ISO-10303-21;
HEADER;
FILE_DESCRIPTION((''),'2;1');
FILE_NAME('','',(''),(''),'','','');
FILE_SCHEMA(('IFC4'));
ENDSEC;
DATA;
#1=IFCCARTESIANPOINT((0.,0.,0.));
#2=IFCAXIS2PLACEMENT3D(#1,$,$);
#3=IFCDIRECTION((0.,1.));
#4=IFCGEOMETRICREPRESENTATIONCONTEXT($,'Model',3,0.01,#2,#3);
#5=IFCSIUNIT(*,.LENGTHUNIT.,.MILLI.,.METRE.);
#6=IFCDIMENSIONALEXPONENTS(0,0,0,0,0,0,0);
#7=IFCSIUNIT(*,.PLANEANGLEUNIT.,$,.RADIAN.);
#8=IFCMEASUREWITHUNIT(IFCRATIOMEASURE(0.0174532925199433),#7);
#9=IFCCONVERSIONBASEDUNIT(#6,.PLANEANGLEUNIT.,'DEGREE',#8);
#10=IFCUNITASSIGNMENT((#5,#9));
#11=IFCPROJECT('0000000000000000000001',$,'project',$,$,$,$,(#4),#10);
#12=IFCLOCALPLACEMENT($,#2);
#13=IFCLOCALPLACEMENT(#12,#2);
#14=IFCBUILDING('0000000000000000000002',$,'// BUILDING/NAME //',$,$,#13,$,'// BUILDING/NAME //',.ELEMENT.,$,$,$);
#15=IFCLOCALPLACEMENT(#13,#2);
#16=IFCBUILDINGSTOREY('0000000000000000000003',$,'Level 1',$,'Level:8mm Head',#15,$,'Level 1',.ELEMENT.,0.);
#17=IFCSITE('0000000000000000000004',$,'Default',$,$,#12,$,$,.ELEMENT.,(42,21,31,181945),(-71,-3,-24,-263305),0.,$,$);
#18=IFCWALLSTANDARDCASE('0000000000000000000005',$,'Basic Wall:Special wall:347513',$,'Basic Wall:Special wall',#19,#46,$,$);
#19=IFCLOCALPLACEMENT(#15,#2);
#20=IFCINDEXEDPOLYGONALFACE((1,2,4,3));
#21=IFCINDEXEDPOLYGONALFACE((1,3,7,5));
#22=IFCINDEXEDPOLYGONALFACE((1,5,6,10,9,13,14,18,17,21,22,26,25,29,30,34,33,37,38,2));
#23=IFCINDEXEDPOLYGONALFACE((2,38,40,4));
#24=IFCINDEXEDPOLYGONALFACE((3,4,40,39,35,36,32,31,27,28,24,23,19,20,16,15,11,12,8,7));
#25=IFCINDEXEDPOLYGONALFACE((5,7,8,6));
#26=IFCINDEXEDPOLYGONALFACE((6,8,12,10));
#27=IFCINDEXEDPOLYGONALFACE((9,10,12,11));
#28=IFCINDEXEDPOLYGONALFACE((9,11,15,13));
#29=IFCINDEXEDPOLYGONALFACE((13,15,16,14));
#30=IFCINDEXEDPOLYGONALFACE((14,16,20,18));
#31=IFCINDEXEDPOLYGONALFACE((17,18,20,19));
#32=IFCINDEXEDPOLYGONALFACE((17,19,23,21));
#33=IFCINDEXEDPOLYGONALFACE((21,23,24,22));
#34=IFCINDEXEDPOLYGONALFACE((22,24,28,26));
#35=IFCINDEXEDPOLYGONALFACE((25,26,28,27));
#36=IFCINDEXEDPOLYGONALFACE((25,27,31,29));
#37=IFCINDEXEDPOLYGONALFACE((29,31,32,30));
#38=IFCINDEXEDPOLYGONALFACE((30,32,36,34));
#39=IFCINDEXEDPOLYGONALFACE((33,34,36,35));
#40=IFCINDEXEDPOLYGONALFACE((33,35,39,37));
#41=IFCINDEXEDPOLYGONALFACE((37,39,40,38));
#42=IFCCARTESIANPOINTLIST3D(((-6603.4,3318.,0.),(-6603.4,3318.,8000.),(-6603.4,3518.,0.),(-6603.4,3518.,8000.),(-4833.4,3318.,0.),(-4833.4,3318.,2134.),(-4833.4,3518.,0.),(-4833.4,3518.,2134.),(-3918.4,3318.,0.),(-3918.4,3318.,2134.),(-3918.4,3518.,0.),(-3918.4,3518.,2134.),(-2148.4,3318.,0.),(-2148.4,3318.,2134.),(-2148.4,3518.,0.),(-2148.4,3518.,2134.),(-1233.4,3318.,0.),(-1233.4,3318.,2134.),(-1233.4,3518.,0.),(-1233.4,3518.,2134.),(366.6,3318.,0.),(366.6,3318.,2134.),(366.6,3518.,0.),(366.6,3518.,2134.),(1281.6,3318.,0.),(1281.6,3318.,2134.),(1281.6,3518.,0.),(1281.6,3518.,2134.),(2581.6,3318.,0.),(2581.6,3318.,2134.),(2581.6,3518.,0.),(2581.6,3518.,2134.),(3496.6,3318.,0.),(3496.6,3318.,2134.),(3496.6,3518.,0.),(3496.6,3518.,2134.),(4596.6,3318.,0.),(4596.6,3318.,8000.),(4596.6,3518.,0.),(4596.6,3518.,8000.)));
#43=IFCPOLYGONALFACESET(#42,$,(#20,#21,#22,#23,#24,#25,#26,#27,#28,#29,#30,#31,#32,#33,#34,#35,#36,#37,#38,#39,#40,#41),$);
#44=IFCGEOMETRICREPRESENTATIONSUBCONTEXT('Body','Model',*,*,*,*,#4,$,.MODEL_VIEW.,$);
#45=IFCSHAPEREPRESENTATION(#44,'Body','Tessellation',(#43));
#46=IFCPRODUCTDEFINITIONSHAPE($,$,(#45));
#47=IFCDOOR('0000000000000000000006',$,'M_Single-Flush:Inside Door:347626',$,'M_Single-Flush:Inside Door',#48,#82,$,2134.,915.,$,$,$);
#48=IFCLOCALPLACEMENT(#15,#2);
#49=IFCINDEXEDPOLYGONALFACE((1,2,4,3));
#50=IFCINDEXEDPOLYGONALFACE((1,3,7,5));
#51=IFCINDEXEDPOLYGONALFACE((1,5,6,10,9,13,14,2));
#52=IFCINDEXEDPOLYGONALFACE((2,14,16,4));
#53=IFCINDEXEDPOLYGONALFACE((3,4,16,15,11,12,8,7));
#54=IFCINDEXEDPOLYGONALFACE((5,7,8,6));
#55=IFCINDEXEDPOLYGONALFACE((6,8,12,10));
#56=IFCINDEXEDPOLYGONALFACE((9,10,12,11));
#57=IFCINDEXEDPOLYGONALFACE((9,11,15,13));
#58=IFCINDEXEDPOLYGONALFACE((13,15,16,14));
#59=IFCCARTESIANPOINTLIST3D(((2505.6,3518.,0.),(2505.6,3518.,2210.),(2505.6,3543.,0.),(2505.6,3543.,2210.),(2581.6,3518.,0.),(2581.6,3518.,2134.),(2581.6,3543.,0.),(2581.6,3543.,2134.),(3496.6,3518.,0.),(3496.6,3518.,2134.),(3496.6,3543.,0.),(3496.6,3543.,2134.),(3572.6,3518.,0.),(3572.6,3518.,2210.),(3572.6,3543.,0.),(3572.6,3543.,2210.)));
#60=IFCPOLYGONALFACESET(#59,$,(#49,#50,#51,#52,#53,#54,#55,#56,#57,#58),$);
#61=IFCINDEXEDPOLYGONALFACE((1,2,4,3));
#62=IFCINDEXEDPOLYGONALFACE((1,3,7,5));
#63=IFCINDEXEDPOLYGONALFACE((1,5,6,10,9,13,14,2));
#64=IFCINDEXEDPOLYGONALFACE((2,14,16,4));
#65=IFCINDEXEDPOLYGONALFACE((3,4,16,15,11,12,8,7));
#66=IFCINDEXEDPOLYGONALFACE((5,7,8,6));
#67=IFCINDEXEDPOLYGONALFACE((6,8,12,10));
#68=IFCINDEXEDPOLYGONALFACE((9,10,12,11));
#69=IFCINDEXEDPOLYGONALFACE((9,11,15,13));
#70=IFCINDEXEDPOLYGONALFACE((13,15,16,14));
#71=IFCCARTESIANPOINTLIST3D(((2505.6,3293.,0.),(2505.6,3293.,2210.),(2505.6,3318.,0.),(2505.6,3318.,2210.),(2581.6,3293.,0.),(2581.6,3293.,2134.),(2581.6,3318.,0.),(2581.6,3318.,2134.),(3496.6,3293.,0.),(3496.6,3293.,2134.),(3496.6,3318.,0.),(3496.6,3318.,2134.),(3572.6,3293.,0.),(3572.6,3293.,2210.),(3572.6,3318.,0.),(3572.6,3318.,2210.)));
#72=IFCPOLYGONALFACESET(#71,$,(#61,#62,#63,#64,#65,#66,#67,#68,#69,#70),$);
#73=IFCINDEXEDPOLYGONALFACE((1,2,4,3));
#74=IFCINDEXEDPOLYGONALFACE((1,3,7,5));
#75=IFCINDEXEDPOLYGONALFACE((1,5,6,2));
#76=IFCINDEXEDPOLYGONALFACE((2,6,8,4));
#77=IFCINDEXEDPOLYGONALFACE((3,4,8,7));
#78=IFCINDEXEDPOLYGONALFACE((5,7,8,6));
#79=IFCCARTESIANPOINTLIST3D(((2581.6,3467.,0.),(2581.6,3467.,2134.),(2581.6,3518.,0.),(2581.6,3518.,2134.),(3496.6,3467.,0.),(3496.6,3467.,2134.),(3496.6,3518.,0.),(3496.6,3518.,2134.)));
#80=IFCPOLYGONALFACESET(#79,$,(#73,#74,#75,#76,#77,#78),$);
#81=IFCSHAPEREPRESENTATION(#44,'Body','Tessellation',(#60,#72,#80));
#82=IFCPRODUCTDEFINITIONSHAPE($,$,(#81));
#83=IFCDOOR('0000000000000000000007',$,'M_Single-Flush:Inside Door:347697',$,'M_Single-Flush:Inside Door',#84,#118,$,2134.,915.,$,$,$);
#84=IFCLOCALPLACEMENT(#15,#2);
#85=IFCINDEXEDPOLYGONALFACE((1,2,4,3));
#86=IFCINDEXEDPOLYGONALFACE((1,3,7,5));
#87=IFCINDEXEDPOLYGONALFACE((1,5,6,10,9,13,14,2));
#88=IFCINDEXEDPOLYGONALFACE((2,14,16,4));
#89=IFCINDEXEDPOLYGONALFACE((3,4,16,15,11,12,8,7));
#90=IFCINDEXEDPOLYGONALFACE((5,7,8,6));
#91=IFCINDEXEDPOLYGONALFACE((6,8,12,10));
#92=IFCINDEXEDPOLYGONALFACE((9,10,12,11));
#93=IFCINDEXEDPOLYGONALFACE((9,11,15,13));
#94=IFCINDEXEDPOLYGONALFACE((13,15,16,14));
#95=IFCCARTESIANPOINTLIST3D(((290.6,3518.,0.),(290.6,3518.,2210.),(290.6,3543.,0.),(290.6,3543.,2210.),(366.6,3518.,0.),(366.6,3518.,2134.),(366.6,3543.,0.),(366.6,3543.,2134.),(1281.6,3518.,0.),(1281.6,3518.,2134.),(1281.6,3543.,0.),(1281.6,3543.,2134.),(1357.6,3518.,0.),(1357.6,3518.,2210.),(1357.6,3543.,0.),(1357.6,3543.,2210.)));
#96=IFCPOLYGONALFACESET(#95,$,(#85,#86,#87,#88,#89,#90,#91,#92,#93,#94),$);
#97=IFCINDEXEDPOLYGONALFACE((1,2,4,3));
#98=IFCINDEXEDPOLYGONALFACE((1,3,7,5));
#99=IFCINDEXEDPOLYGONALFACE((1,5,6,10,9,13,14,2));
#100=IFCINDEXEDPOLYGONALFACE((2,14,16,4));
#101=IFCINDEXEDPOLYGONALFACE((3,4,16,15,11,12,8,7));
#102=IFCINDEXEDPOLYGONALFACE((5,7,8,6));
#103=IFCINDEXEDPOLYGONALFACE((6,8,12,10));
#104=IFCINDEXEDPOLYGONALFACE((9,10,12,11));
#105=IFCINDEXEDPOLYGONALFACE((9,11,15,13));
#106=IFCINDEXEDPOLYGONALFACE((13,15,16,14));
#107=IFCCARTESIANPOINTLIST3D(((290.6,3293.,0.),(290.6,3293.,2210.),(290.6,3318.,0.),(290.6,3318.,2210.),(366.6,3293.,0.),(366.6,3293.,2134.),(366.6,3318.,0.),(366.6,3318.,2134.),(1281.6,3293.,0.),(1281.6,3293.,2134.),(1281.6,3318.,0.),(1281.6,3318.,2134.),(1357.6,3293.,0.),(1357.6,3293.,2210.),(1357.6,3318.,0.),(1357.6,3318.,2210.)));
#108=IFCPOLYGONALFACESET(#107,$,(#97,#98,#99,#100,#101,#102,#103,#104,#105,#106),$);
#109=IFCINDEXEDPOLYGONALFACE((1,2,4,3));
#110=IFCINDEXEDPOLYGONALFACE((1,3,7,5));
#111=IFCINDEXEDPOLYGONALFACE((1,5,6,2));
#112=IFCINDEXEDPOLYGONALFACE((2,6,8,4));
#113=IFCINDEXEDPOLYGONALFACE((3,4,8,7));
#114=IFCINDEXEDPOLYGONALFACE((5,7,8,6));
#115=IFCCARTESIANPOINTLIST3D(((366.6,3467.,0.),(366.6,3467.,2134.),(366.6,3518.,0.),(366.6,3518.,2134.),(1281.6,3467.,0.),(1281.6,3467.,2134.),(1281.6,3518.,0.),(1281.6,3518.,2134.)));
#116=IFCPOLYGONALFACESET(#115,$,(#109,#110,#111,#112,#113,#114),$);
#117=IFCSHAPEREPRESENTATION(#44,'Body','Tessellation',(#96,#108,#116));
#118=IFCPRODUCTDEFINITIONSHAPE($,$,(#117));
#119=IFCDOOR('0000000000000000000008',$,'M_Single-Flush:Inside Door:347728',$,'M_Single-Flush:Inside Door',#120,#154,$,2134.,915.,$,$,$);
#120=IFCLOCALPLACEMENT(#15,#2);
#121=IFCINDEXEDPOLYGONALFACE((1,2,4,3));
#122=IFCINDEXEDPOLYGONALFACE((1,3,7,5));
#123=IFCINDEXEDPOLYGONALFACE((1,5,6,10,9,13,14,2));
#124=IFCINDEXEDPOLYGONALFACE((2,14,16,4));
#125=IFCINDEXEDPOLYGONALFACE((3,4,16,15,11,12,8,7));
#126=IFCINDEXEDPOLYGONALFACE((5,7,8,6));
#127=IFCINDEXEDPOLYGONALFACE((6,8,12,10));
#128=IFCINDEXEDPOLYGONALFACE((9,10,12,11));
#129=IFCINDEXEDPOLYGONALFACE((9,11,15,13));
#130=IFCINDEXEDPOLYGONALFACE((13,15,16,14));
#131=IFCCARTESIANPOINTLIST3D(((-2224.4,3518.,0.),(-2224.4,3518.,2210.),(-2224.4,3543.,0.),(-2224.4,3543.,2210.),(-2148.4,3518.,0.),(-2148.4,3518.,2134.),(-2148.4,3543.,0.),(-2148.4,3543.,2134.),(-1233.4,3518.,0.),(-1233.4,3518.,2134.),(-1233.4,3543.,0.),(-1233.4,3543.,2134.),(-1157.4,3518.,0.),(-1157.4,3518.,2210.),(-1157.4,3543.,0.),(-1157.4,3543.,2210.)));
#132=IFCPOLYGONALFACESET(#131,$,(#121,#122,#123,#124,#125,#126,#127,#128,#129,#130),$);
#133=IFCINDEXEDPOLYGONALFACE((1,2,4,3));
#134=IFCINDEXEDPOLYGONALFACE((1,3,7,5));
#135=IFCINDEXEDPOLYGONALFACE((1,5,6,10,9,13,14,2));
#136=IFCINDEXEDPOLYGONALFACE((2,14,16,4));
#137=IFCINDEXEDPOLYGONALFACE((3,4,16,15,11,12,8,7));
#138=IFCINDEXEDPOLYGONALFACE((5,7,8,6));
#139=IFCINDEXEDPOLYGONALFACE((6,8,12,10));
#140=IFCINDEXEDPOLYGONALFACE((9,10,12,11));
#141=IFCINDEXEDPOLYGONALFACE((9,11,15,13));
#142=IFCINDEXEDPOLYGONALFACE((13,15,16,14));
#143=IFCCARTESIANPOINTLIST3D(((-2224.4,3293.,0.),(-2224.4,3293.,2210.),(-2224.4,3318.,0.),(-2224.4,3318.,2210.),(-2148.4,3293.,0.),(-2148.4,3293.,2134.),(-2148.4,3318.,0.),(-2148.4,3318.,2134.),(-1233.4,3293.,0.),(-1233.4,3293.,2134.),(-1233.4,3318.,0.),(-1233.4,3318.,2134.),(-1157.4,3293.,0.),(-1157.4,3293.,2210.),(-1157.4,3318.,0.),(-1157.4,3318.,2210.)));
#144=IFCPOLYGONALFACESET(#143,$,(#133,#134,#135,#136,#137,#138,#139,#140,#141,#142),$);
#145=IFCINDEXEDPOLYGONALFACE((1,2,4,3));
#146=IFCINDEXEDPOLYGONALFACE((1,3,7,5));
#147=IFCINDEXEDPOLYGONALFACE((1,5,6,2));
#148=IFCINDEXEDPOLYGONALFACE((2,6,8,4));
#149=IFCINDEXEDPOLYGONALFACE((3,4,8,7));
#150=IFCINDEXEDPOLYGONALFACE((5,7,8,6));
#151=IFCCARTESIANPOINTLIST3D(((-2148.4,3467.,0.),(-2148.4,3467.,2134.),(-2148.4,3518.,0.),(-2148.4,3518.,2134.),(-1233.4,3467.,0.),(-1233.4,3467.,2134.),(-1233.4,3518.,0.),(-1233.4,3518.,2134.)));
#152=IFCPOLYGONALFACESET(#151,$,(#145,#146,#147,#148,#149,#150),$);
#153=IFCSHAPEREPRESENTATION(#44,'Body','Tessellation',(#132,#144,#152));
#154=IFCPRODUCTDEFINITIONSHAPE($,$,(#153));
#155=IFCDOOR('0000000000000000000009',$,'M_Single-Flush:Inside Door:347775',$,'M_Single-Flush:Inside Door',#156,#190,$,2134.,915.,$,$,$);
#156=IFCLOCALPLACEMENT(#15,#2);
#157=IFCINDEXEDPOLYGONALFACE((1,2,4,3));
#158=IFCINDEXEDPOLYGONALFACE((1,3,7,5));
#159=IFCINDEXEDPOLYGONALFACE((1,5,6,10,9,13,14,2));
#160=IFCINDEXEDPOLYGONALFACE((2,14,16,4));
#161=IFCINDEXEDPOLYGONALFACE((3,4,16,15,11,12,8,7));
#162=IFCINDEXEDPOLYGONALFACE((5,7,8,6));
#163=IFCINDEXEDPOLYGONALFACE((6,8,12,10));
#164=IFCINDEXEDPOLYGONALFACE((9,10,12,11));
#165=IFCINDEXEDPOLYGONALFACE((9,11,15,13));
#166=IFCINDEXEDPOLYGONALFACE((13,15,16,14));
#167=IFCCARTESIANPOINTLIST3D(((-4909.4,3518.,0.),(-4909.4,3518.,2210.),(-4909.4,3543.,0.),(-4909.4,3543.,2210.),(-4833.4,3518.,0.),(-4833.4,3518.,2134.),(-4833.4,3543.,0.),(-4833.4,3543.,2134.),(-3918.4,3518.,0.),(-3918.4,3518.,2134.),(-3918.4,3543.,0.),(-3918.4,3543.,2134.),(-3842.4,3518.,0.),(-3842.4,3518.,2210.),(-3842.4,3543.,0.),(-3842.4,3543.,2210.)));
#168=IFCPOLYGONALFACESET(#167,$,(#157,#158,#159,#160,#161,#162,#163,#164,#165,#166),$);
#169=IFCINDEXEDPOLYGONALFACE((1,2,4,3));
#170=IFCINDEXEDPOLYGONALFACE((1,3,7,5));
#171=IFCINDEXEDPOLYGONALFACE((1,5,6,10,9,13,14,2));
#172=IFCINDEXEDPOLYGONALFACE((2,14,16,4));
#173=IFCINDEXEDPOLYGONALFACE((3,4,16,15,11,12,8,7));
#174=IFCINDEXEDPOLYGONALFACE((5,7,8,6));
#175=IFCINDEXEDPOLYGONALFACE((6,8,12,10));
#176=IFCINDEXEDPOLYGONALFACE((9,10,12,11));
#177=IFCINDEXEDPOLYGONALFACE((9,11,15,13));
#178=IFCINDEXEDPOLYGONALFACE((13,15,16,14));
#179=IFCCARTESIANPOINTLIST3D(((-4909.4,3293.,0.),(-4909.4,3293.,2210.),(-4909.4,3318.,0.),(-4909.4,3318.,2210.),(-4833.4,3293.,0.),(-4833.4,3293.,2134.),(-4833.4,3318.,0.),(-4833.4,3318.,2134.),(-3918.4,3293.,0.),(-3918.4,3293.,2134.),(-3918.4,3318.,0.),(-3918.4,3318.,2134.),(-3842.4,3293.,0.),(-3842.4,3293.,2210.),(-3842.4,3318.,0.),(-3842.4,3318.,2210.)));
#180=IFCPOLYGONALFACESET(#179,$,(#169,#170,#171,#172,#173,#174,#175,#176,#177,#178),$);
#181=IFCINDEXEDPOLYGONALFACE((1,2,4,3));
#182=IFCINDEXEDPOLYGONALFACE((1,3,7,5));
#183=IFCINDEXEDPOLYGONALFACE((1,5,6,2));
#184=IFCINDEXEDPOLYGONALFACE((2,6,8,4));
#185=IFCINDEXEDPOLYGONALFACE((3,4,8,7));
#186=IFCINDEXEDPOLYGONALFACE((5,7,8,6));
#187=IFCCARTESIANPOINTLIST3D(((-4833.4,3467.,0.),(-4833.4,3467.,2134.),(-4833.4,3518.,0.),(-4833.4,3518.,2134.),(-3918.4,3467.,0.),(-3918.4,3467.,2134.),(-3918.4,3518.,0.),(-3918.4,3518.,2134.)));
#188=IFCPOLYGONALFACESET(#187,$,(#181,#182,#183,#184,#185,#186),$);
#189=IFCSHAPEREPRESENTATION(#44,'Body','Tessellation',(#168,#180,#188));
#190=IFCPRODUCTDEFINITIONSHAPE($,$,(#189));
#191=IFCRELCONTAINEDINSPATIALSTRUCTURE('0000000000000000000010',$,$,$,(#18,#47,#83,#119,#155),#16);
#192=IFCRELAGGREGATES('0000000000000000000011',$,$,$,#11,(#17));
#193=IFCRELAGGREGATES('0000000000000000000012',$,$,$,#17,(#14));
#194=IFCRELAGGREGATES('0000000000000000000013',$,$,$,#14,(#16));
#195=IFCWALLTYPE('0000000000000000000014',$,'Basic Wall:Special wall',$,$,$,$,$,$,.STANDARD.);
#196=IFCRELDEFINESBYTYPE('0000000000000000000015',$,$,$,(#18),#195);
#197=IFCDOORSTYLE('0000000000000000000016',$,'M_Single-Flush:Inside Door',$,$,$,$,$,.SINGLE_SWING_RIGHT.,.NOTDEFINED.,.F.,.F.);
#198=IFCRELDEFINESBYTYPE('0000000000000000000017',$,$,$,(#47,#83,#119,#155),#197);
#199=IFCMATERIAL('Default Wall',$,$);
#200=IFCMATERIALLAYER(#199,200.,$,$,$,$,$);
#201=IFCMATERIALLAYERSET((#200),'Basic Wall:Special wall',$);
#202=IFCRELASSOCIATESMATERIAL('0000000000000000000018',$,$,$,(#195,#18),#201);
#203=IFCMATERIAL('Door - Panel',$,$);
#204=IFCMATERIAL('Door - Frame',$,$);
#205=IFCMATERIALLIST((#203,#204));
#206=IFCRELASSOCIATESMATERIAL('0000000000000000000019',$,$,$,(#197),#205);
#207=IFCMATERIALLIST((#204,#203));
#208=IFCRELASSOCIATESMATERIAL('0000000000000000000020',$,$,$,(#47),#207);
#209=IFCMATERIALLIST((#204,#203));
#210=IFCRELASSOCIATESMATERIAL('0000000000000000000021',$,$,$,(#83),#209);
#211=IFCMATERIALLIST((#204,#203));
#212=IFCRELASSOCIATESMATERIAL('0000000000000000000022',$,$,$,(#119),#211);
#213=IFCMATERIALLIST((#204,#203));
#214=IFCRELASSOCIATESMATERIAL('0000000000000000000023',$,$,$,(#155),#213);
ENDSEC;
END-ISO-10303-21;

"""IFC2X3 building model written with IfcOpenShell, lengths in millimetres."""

from ifc_helpers import new_model, entity, si_unit, converted_unit, direction, frame, frame_2d, origin, place, context, subcontext, project, spatial, polyline, rectangle, outline, extrude, source, transform, mapped, material, material_list, layer, layer_set, layer_usage, type_object, type_shapes, element, fill, save


model = new_model("IFC2X3")

# Units and contexts
model_context = context("Model", 3, precision=0.01, world=origin(), true_north=direction((0.0, 1.0)))
body_context = subcontext(model_context, "Body", "Model", "MODEL_VIEW")
ifc_project = project(units=[si_unit("LENGTHUNIT", "METRE", prefix="MILLI"), converted_unit("PLANEANGLEUNIT", "DEGREE", entity("IfcRatioMeasure", 0.0174532925199433), si_unit("PLANEANGLEUNIT", "RADIAN"), dimensions=[0, 0, 0, 0, 0, 0, 0])], contexts=[model_context])

# Site, building, storey
site_placement = place(None, origin())
site = spatial("IfcSite", under=ifc_project, at=site_placement, Name="Default", CompositionType="ELEMENT", RefLatitude=(42, 21, 31, 181945), RefLongitude=(-71, -3, -24, -263305), RefElevation=0.0)
building_placement = place(site_placement, origin())
building = spatial("IfcBuilding", under=site, at=building_placement, Name="// BUILDING/NAME //", LongName="// BUILDING/NAME //", CompositionType="ELEMENT")
storey_placement = place(building_placement, origin())
storey = spatial("IfcBuildingStorey", under=building, at=storey_placement, Name="Level 1", ObjectType="Level:8mm Head", LongName="Level 1", CompositionType="ELEMENT", Elevation=0.0)

# Wall, openings, doors
ifc_material_1 = material(Name="Default Wall")
ifc_material_2 = material(Name="Door - Frame")
ifc_material_3 = material(Name="Door - Panel")
ifc_layer_1 = layer(ifc_material_1, 200.0)
ifc_layer_set_1 = layer_set([ifc_layer_1], Name="Basic Wall:Special wall")
ifc_layer_usage_1 = layer_usage(ifc_layer_set_1, "AXIS2", "NEGATIVE", 100.0)
wall_type_1 = type_object("IfcWallType", Name="Basic Wall:Special wall", PredefinedType="STANDARD", material=ifc_layer_set_1)
wall_1_placement = place(storey_placement, frame((-6603.4, 3418.0, 0.0)))
wall_1 = element("IfcWallStandardCase", 1, at=wall_1_placement, inside=storey, type_object=wall_type_1, material=ifc_layer_usage_1, Name="Basic Wall:Special wall:347513", ObjectType="Basic Wall:Special wall", context=body_context, shape_type="SweptSolid", body=[
    extrude(rectangle(XDim=11200.0, YDim=200.0, at=frame_2d((5600.0, 0.0), x_axis=(-1.0, 0.0))), origin(), (0.0, 0.0, 1.0), 8000.0),
])
opening_1_placement = place(wall_1_placement, frame((9185.0, -100.0, 0.0)))
opening_1 = element("IfcOpeningElement", 2, at=opening_1_placement, cuts=wall_1, ObjectType="Opening", context=body_context, shape_type="SweptSolid", body=[
    extrude(rectangle(XDim=915.0, YDim=2134.0, at=frame_2d((1067.0, 457.5), x_axis=(0.0, 1.0))), frame((0.0, 0.0, 0.0), z_axis=(0.0, 1.0, 0.0), x_axis=(0.0, 0.0, 1.0)), (0.0, 0.0, 1.0), 200.0),
])
opening_2_placement = place(wall_1_placement, frame((6970.0, -100.0, 0.0)))
opening_2 = element("IfcOpeningElement", 3, at=opening_2_placement, cuts=wall_1, ObjectType="Opening", context=body_context, shape_type="SweptSolid", body=[
    extrude(rectangle(XDim=915.0, YDim=2134.0, at=frame_2d((1067.0, 457.5), x_axis=(0.0, 1.0))), frame((0.0, 0.0, 0.0), z_axis=(0.0, 1.0, 0.0), x_axis=(0.0, 0.0, 1.0)), (0.0, 0.0, 1.0), 200.0),
])
opening_3_placement = place(wall_1_placement, frame((4455.0, -100.0, 0.0)))
opening_3 = element("IfcOpeningElement", 4, at=opening_3_placement, cuts=wall_1, ObjectType="Opening", context=body_context, shape_type="SweptSolid", body=[
    extrude(rectangle(XDim=915.0, YDim=2134.0, at=frame_2d((1067.0, 457.5), x_axis=(0.0, 1.0))), frame((0.0, 0.0, 0.0), z_axis=(0.0, 1.0, 0.0), x_axis=(0.0, 0.0, 1.0)), (0.0, 0.0, 1.0), 200.0),
])
opening_4_placement = place(wall_1_placement, frame((1770.0, -100.0, 0.0)))
opening_4 = element("IfcOpeningElement", 5, at=opening_4_placement, cuts=wall_1, ObjectType="Opening", context=body_context, shape_type="SweptSolid", body=[
    extrude(rectangle(XDim=915.0, YDim=2134.0, at=frame_2d((1067.0, 457.5), x_axis=(0.0, 1.0))), frame((0.0, 0.0, 0.0), z_axis=(0.0, 1.0, 0.0), x_axis=(0.0, 0.0, 1.0)), (0.0, 0.0, 1.0), 200.0),
])
ifc_material_list_1 = material_list([ifc_material_2, ifc_material_3])
ifc_material_list_2 = material_list([ifc_material_3, ifc_material_2])
door_style_1 = type_object("IfcDoorStyle", Name="M_Single-Flush:Inside Door", ConstructionType="NOTDEFINED", OperationType="SINGLE_SWING_RIGHT", ParameterTakesPrecedence=False, Sizeable=False, material=ifc_material_list_2)
shared_shape_1 = source(origin(), body_context, "Body", "SweptSolid", [
    extrude(outline(polyline([(-533.5, -1124.0), (533.5, -1124.0), (533.5, 1086.0), (457.5, 1086.0), (457.5, -1048.0), (-457.5, -1048.0), (-457.5, 1086.0), (-533.5, 1086.0), (-533.5, -1124.0)])), frame((457.5, 200.0, 1086.0), z_axis=(0.0, 1.0, 0.0), x_axis=(1.0, 0.0, 0.0)), (0.0, 0.0, 1.0), 25.0),
    extrude(outline(polyline([(-1124.0, -533.5), (1086.0, -533.5), (1086.0, -457.5), (-1048.0, -457.5), (-1048.0, 457.5), (1086.0, 457.5), (1086.0, 533.5), (-1124.0, 533.5), (-1124.0, -533.5)])), frame((457.5, -25.0, 1086.0), z_axis=(0.0, 1.0, 0.0), x_axis=(0.0, 0.0, -1.0)), (0.0, 0.0, 1.0), 25.0),
    extrude(rectangle(XDim=51.0, YDim=915.0, at=frame_2d((0.0, 0.0), x_axis=(1.0, 0.0))), frame((457.5, 174.5, 0.0), z_axis=(0.0, 0.0, 1.0), x_axis=(0.0, 1.0, 0.0)), (0.0, 0.0, 1.0), 2134.0),
])
type_shapes(door_style_1, [shared_shape_1])
door_1_placement = place(opening_1_placement, origin())
door_1 = element("IfcDoor", 6, at=door_1_placement, inside=storey, type_object=door_style_1, material=ifc_material_list_1, Name="M_Single-Flush:Inside Door:347626", ObjectType="M_Single-Flush:Inside Door", OverallHeight=2134.0, OverallWidth=915.0, context=body_context, shape_type="MappedRepresentation", body=[
    mapped(shared_shape_1, transform((0.0, 0.0, 0.0), scale=1.0)),
])
fill(opening_1, door_1)
ifc_material_list_3 = material_list([ifc_material_2, ifc_material_3])
door_2_placement = place(opening_2_placement, origin())
door_2 = element("IfcDoor", 7, at=door_2_placement, inside=storey, type_object=door_style_1, material=ifc_material_list_3, Name="M_Single-Flush:Inside Door:347697", ObjectType="M_Single-Flush:Inside Door", OverallHeight=2134.0, OverallWidth=915.0, context=body_context, shape_type="MappedRepresentation", body=[
    mapped(shared_shape_1, transform((0.0, 0.0, 0.0), scale=1.0)),
])
fill(opening_2, door_2)
ifc_material_list_4 = material_list([ifc_material_2, ifc_material_3])
door_3_placement = place(opening_3_placement, origin())
door_3 = element("IfcDoor", 8, at=door_3_placement, inside=storey, type_object=door_style_1, material=ifc_material_list_4, Name="M_Single-Flush:Inside Door:347728", ObjectType="M_Single-Flush:Inside Door", OverallHeight=2134.0, OverallWidth=915.0, context=body_context, shape_type="MappedRepresentation", body=[
    mapped(shared_shape_1, transform((0.0, 0.0, 0.0), scale=1.0)),
])
fill(opening_3, door_3)
ifc_material_list_5 = material_list([ifc_material_2, ifc_material_3])
door_4_placement = place(opening_4_placement, origin())
door_4 = element("IfcDoor", 9, at=door_4_placement, inside=storey, type_object=door_style_1, material=ifc_material_list_5, Name="M_Single-Flush:Inside Door:347775", ObjectType="M_Single-Flush:Inside Door", OverallHeight=2134.0, OverallWidth=915.0, context=body_context, shape_type="MappedRepresentation", body=[
    mapped(shared_shape_1, transform((0.0, 0.0, 0.0), scale=1.0)),
])
fill(opening_4, door_4)

save(model, "model.ifc")
